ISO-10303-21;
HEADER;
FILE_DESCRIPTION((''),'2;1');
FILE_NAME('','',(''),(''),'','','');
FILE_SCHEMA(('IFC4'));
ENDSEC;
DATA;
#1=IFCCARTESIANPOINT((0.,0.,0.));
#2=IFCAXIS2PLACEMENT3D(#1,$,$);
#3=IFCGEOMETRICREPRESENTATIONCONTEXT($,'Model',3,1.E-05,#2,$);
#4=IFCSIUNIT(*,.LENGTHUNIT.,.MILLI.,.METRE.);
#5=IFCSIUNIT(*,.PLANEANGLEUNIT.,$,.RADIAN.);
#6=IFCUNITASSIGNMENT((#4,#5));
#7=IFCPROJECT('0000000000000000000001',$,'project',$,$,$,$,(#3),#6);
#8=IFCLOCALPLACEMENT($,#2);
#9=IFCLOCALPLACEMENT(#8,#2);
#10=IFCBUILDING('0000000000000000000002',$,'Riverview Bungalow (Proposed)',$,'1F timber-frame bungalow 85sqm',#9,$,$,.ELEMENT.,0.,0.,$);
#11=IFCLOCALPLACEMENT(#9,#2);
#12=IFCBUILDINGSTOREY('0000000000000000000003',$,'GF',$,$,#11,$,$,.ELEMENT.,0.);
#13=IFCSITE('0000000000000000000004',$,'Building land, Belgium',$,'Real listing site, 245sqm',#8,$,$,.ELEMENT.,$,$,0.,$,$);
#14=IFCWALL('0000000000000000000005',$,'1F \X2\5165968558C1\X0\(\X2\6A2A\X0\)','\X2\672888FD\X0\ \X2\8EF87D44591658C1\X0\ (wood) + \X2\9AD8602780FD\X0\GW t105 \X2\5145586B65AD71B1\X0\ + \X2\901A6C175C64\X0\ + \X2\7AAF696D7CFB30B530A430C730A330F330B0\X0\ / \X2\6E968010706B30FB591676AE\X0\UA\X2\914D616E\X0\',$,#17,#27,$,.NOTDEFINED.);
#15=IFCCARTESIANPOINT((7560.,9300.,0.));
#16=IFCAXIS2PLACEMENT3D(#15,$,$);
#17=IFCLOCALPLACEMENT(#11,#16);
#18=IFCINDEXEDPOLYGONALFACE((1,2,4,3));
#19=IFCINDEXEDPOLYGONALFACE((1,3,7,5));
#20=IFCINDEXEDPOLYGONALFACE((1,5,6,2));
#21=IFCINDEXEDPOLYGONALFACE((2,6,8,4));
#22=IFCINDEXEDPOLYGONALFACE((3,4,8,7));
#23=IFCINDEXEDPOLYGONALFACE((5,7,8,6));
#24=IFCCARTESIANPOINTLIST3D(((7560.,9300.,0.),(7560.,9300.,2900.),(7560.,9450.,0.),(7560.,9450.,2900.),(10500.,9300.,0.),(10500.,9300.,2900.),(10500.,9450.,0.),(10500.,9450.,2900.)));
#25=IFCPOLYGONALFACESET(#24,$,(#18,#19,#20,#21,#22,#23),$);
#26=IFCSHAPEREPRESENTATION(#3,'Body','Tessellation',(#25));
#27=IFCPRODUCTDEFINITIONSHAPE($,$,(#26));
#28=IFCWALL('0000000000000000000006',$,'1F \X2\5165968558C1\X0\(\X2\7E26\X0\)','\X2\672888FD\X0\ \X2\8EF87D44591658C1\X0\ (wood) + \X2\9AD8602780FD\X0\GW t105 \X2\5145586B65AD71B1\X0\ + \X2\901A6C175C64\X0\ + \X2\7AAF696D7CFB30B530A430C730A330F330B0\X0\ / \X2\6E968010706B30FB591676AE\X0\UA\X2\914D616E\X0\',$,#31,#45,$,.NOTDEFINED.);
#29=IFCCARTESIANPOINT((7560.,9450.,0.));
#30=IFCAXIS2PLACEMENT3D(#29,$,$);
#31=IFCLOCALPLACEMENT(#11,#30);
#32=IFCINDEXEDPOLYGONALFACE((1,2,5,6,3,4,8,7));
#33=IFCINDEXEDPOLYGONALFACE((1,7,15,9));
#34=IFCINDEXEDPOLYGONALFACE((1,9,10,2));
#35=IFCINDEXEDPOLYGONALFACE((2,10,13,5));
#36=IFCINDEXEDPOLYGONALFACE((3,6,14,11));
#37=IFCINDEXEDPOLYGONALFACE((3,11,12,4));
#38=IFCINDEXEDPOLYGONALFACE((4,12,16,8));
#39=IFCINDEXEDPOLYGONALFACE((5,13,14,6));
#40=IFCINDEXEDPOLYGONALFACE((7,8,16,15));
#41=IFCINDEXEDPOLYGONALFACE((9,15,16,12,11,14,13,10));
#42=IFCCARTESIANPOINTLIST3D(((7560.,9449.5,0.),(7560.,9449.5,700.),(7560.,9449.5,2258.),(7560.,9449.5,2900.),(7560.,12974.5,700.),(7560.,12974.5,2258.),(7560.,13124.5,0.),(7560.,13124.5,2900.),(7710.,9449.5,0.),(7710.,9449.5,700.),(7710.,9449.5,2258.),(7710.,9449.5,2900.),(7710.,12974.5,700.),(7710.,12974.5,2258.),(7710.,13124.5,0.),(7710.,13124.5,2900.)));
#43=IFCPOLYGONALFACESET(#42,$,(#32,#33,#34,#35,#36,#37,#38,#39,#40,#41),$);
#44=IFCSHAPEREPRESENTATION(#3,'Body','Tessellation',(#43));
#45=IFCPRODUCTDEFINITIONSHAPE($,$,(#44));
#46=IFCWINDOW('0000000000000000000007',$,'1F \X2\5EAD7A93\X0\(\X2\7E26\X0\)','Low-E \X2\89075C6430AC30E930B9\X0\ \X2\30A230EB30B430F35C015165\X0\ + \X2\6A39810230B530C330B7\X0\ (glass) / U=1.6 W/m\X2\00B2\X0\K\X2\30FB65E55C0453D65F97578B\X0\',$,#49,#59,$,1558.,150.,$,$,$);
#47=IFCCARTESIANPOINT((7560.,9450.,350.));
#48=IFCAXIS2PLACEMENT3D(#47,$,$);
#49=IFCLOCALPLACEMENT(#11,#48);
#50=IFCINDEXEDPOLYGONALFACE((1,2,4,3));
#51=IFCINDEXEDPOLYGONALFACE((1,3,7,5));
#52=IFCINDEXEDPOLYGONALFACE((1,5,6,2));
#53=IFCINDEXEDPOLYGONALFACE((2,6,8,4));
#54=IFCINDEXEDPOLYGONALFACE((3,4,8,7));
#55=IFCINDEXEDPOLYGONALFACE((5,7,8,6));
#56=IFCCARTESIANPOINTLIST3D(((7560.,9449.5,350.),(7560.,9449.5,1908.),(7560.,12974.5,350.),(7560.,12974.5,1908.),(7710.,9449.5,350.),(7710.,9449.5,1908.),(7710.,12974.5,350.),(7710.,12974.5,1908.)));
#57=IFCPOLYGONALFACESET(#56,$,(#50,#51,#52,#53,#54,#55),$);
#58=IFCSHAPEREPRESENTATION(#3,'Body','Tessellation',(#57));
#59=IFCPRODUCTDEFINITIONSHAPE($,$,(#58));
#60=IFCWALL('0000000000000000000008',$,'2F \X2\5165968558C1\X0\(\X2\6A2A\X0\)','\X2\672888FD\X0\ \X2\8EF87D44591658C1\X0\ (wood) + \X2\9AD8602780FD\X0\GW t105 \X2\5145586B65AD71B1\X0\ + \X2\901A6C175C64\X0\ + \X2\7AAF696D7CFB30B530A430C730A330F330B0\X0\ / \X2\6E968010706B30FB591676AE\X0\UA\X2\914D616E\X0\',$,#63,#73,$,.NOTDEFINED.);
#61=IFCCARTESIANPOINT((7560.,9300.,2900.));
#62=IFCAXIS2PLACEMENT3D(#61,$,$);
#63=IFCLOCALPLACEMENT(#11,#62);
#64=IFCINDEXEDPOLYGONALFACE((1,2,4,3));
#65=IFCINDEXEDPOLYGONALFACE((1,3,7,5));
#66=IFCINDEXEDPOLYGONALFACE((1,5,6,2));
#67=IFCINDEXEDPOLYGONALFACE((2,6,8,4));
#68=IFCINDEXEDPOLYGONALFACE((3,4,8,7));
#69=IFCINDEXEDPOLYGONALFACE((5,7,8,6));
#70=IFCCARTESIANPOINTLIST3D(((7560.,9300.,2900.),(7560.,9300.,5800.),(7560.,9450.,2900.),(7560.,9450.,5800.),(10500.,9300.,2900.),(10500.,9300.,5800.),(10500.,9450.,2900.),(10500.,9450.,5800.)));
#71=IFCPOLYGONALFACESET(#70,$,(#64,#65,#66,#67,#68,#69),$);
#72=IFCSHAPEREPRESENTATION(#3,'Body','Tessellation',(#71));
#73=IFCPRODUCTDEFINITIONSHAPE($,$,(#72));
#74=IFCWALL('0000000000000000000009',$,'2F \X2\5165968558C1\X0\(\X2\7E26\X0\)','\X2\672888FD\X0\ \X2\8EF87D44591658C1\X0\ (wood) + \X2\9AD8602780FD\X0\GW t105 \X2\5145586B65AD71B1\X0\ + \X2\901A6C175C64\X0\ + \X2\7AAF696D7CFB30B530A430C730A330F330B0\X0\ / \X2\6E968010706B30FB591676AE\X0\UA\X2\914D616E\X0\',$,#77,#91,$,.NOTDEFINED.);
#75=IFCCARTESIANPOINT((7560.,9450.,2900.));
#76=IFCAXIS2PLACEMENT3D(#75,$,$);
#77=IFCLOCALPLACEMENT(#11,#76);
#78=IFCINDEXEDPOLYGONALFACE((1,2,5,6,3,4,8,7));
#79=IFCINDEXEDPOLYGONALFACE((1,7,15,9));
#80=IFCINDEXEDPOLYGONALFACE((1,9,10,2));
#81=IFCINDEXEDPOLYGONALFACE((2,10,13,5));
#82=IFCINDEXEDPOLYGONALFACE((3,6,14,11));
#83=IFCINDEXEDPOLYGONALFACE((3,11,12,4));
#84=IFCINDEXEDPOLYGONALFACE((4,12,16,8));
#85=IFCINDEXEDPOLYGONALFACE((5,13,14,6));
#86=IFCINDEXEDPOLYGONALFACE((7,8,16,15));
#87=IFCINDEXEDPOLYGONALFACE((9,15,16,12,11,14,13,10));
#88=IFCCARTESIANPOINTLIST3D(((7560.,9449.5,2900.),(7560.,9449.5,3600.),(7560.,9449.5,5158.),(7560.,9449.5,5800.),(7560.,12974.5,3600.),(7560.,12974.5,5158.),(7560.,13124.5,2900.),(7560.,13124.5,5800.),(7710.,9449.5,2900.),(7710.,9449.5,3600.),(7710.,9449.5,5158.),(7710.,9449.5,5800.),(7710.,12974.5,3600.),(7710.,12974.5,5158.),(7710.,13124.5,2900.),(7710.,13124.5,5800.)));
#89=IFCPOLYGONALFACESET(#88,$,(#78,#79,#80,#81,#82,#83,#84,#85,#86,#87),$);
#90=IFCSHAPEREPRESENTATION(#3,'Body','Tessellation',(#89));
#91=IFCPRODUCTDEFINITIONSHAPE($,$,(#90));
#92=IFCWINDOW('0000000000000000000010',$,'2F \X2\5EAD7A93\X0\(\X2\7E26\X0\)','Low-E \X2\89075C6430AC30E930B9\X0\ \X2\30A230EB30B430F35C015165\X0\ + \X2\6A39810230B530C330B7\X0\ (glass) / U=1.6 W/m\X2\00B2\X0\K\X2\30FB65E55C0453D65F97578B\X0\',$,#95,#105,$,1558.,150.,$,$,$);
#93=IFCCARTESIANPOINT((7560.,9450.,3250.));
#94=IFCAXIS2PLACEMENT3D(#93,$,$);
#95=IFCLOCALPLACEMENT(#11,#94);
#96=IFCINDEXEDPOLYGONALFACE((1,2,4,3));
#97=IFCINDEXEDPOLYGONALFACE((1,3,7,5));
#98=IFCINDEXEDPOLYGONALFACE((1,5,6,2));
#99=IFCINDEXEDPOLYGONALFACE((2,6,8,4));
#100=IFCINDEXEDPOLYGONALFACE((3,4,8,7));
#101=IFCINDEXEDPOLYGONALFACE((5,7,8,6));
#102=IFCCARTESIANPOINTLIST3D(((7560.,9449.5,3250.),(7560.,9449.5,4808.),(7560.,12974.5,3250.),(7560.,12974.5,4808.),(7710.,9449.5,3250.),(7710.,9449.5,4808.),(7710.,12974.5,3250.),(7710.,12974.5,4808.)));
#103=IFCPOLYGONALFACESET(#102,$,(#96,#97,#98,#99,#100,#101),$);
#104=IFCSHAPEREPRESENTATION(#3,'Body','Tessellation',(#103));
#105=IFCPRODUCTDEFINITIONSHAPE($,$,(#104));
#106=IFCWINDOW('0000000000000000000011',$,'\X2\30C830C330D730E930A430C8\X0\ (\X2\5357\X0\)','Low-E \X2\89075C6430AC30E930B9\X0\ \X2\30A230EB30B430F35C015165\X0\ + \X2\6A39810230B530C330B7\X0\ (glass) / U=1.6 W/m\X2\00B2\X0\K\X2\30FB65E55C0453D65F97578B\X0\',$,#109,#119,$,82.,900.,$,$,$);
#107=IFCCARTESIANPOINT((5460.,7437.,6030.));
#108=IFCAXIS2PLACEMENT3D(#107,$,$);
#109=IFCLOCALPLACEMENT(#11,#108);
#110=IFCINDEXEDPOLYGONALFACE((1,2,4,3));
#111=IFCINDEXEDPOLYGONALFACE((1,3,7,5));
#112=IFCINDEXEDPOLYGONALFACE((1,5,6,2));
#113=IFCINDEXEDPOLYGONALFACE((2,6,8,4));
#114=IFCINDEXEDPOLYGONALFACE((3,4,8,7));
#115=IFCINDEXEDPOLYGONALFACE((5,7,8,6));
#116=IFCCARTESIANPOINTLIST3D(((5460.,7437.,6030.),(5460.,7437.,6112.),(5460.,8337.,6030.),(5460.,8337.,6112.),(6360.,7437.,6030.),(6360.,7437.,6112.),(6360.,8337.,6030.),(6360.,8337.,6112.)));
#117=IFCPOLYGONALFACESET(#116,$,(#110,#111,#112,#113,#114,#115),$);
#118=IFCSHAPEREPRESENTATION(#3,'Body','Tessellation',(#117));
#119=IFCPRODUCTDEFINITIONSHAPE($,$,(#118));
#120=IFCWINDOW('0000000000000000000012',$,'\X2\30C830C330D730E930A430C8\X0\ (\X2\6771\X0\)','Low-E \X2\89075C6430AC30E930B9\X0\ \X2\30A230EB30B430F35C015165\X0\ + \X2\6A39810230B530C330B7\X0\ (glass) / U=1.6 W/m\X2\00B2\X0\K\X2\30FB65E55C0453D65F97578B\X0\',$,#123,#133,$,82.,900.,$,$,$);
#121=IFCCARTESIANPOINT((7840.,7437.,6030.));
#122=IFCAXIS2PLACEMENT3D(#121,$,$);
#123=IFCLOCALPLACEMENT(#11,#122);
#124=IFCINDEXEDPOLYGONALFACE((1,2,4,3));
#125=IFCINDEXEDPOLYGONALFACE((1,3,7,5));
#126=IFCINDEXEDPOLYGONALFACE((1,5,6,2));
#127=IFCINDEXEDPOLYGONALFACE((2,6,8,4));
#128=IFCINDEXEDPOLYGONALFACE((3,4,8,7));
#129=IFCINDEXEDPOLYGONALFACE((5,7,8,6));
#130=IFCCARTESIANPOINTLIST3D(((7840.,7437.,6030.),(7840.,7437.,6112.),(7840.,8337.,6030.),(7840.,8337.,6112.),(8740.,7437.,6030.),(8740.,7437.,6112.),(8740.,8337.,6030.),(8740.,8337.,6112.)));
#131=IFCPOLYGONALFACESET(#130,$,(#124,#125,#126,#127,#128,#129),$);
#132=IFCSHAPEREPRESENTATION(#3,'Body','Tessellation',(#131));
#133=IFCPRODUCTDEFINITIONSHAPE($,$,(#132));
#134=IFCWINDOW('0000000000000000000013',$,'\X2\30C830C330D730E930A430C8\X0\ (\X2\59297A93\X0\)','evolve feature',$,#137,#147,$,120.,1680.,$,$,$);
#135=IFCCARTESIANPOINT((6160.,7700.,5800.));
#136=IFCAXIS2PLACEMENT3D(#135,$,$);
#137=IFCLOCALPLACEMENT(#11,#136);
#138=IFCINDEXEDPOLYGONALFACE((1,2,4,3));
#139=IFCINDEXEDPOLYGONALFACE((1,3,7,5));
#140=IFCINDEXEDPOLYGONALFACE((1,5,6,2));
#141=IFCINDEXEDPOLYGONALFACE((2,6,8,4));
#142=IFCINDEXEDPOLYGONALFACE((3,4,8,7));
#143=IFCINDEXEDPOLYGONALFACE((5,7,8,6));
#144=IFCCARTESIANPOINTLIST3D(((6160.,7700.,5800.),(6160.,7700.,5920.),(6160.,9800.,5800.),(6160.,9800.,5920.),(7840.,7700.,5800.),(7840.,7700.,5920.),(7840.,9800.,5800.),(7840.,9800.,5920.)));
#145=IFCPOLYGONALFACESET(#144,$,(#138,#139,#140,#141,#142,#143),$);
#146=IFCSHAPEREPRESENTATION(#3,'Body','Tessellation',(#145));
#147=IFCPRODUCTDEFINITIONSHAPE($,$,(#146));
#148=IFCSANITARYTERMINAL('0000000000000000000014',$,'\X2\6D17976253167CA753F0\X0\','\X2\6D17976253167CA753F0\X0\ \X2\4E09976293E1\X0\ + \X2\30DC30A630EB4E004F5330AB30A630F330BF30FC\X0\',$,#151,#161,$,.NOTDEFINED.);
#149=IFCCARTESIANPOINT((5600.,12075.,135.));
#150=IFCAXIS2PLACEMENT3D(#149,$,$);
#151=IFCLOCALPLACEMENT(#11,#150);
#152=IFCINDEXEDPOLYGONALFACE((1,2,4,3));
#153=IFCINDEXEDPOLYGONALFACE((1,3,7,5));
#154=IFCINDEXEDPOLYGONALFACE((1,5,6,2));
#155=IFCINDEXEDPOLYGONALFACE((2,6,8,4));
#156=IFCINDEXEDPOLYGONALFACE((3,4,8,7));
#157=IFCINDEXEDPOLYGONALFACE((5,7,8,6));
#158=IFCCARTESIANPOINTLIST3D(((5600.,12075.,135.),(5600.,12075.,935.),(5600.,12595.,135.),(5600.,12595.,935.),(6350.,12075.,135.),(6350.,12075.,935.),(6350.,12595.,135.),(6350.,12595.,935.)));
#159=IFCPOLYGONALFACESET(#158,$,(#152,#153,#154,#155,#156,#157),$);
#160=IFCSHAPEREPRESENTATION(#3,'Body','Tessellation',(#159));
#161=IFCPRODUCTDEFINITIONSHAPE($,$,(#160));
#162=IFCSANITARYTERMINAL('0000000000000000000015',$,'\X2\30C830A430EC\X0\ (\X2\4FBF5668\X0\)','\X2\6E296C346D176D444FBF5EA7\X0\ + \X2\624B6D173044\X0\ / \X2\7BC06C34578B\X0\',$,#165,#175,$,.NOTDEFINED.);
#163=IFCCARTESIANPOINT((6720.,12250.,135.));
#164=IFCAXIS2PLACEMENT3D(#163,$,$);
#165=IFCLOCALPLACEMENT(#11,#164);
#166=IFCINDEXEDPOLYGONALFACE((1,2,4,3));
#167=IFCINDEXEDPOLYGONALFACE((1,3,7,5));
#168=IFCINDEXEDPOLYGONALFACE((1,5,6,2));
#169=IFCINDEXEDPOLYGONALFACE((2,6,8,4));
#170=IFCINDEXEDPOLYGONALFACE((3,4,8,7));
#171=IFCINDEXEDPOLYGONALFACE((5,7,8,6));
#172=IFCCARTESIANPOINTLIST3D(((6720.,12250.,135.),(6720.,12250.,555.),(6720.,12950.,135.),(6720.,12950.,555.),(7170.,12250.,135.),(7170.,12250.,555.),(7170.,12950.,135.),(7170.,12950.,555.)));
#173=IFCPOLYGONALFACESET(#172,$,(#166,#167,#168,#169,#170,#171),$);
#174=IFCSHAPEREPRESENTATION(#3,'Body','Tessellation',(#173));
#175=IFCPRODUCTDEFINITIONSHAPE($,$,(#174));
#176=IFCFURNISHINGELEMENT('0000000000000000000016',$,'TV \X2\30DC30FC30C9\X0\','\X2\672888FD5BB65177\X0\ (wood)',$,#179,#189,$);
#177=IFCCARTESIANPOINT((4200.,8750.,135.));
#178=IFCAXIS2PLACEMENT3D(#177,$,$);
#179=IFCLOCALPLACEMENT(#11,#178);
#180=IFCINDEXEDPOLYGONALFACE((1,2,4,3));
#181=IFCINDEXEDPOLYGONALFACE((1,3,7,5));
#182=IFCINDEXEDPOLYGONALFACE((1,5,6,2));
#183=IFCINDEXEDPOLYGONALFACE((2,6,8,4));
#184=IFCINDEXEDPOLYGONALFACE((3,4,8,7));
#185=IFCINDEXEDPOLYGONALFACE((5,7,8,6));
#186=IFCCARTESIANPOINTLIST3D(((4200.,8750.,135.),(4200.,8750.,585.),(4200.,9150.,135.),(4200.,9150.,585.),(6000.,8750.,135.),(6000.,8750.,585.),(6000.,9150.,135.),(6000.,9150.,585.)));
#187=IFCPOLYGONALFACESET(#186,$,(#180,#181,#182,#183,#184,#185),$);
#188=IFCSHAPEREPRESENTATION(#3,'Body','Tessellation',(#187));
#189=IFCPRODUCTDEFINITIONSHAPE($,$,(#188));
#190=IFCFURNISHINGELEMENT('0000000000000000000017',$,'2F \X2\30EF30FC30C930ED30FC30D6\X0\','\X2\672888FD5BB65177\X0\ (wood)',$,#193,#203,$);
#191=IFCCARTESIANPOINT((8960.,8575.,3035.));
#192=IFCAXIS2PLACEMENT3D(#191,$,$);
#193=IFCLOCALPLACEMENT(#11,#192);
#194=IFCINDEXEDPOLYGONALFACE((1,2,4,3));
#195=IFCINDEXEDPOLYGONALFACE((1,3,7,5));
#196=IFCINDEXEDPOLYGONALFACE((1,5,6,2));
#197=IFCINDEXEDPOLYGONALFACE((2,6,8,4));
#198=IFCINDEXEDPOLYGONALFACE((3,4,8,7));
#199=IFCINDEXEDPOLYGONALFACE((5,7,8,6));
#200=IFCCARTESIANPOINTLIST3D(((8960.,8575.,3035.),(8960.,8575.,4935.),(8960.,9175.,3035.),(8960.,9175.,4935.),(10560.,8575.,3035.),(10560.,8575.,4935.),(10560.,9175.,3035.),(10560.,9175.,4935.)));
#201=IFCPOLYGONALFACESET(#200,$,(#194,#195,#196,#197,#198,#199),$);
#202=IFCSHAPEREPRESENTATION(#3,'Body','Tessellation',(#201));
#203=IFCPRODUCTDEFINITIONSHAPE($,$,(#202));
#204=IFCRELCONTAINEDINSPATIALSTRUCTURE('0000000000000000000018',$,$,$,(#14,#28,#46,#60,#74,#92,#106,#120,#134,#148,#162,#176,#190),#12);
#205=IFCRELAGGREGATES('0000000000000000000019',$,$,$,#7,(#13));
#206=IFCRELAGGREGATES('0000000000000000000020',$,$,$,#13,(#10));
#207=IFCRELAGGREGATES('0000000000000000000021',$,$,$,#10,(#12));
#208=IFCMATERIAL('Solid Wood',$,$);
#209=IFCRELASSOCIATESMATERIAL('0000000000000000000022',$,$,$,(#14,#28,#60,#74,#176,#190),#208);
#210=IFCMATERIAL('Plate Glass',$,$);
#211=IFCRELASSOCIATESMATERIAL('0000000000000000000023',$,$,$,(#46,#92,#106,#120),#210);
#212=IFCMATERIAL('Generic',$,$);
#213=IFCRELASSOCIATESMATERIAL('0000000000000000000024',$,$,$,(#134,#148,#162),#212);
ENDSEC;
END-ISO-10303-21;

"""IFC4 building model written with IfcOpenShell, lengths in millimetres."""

from ifc_helpers import new_model, si_unit, frame, frame_2d, origin, place, context, project, spatial, rectangle, extrude, material, element, fill, save


model = new_model("IFC4")

# Units and contexts
model_context = context("Model", 3, precision=1e-05, world=origin())
ifc_project = project(units=[si_unit("LENGTHUNIT", "METRE", prefix="MILLI"), si_unit("PLANEANGLEUNIT", "RADIAN")], contexts=[model_context])

# Site, building, storey
site_placement = place(None, origin())
site = spatial("IfcSite", under=ifc_project, at=site_placement, Name="Building land, Belgium", ObjectType="Real listing site, 245sqm", CompositionType="ELEMENT", RefElevation=0.0)
building_placement = place(site_placement, origin())
building = spatial("IfcBuilding", under=site, at=building_placement, Name="Riverview Bungalow (Proposed)", ObjectType="1F timber-frame bungalow 85sqm", CompositionType="ELEMENT", ElevationOfRefHeight=0.0, ElevationOfTerrain=0.0)
storey_placement = place(building_placement, origin())
storey = spatial("IfcBuildingStorey", under=building, at=storey_placement, Name="GF", CompositionType="ELEMENT", Elevation=0.0)

# Shared definitions
ifc_material_1 = material(Name="Solid Wood")

# Wall
wall_1_placement = place(storey_placement, frame((7560.0, 9300.0, 0.0)))
element("IfcWall", 1, at=wall_1_placement, inside=storey, material=ifc_material_1, Name="1F 入隅壁(横)", Description="木製 軸組外壁 (wood) + 高性能GW t105 充填断熱 + 通気層 + 窯業系サイディング / 準耐火・外皮UA配慮", PredefinedType="NOTDEFINED", context=model_context, shape_type="SweptSolid", body=[
    extrude(rectangle(XDim=2940.0, YDim=150.0, at=frame_2d((1470.0, 75.0))), frame((7560.0, 9300.0, 0.0)), (0.0, 0.0, 1.0), 2900.0),
])

# Wall, opening, window
wall_2_placement = place(storey_placement, frame((7560.0, 9450.0, 0.0)))
wall_2 = element("IfcWall", 2, at=wall_2_placement, inside=storey, material=ifc_material_1, Name="1F 入隅壁(縦)", Description="木製 軸組外壁 (wood) + 高性能GW t105 充填断熱 + 通気層 + 窯業系サイディング / 準耐火・外皮UA配慮", PredefinedType="NOTDEFINED", context=model_context, shape_type="SweptSolid", body=[
    extrude(rectangle(XDim=150.0, YDim=3675.0, at=frame_2d((75.0, 1837.0))), frame((7560.0, 9450.0, 0.0)), (0.0, 0.0, 1.0), 2900.0),
])
opening_1_placement = place(storey_placement, frame((7560.0, 9450.0, 350.0)))
opening_1 = element("IfcOpeningElement", 3, at=opening_1_placement, cuts=wall_2, PredefinedType="NOTDEFINED", context=model_context, shape_type="SweptSolid", body=[
    extrude(rectangle(XDim=150.0, YDim=3525.0, at=frame_2d((75.0, 1762.0))), frame((7560.0, 9450.0, 350.0)), (0.0, 0.0, 1.0), 1558.0),
])
ifc_material_2 = material(Name="Plate Glass")
window_1_placement = place(storey_placement, frame((7560.0, 9450.0, 350.0)))
window_1 = element("IfcWindow", 4, at=window_1_placement, inside=storey, material=ifc_material_2, Name="1F 庭窓(縦)", Description="Low-E 複層ガラス アルゴン封入 + 樹脂サッシ (glass) / U=1.6 W/m²K・日射取得型", OverallHeight=1558.0, OverallWidth=150.0, context=model_context, shape_type="SweptSolid", body=[
    extrude(rectangle(XDim=150.0, YDim=3525.0, at=frame_2d((75.0, 1762.0))), frame((7560.0, 9450.0, 350.0)), (0.0, 0.0, 1.0), 1558.0),
])
fill(opening_1, window_1)

# Wall
wall_3_placement = place(storey_placement, frame((7560.0, 9300.0, 2900.0)))
element("IfcWall", 5, at=wall_3_placement, inside=storey, material=ifc_material_1, Name="2F 入隅壁(横)", Description="木製 軸組外壁 (wood) + 高性能GW t105 充填断熱 + 通気層 + 窯業系サイディング / 準耐火・外皮UA配慮", PredefinedType="NOTDEFINED", context=model_context, shape_type="SweptSolid", body=[
    extrude(rectangle(XDim=2940.0, YDim=150.0, at=frame_2d((1470.0, 75.0))), frame((7560.0, 9300.0, 2900.0)), (0.0, 0.0, 1.0), 2900.0),
])

# Wall, opening, window
wall_4_placement = place(storey_placement, frame((7560.0, 9450.0, 2900.0)))
wall_4 = element("IfcWall", 6, at=wall_4_placement, inside=storey, material=ifc_material_1, Name="2F 入隅壁(縦)", Description="木製 軸組外壁 (wood) + 高性能GW t105 充填断熱 + 通気層 + 窯業系サイディング / 準耐火・外皮UA配慮", PredefinedType="NOTDEFINED", context=model_context, shape_type="SweptSolid", body=[
    extrude(rectangle(XDim=150.0, YDim=3675.0, at=frame_2d((75.0, 1837.0))), frame((7560.0, 9450.0, 2900.0)), (0.0, 0.0, 1.0), 2900.0),
])
opening_2_placement = place(storey_placement, frame((7560.0, 9450.0, 3250.0)))
opening_2 = element("IfcOpeningElement", 7, at=opening_2_placement, cuts=wall_4, PredefinedType="NOTDEFINED", context=model_context, shape_type="SweptSolid", body=[
    extrude(rectangle(XDim=150.0, YDim=3525.0, at=frame_2d((75.0, 1762.0))), frame((7560.0, 9450.0, 3250.0)), (0.0, 0.0, 1.0), 1558.0),
])
window_2_placement = place(storey_placement, frame((7560.0, 9450.0, 3250.0)))
window_2 = element("IfcWindow", 8, at=window_2_placement, inside=storey, material=ifc_material_2, Name="2F 庭窓(縦)", Description="Low-E 複層ガラス アルゴン封入 + 樹脂サッシ (glass) / U=1.6 W/m²K・日射取得型", OverallHeight=1558.0, OverallWidth=150.0, context=model_context, shape_type="SweptSolid", body=[
    extrude(rectangle(XDim=150.0, YDim=3525.0, at=frame_2d((75.0, 1762.0))), frame((7560.0, 9450.0, 3250.0)), (0.0, 0.0, 1.0), 1558.0),
])
fill(opening_2, window_2)

# Windows
window_3_placement = place(storey_placement, frame((5460.0, 7437.0, 6030.0)))
element("IfcWindow", 9, at=window_3_placement, inside=storey, material=ifc_material_2, Name="トップライト (南)", Description="Low-E 複層ガラス アルゴン封入 + 樹脂サッシ (glass) / U=1.6 W/m²K・日射取得型", OverallHeight=82.0, OverallWidth=900.0, context=model_context, shape_type="SweptSolid", body=[
    extrude(rectangle(XDim=900.0, YDim=900.0, at=frame_2d((450.0, 450.0))), frame((5460.0, 7437.0, 6030.0)), (0.0, 0.0, 1.0), 82.0),
])
window_4_placement = place(storey_placement, frame((7840.0, 7437.0, 6030.0)))
element("IfcWindow", 10, at=window_4_placement, inside=storey, material=ifc_material_2, Name="トップライト (東)", Description="Low-E 複層ガラス アルゴン封入 + 樹脂サッシ (glass) / U=1.6 W/m²K・日射取得型", OverallHeight=82.0, OverallWidth=900.0, context=model_context, shape_type="SweptSolid", body=[
    extrude(rectangle(XDim=900.0, YDim=900.0, at=frame_2d((450.0, 450.0))), frame((7840.0, 7437.0, 6030.0)), (0.0, 0.0, 1.0), 82.0),
])
ifc_material_3 = material(Name="Generic")
window_5_placement = place(storey_placement, frame((6160.0, 7700.0, 5800.0)))
element("IfcWindow", 11, at=window_5_placement, inside=storey, material=ifc_material_3, Name="トップライト (天窓)", Description="evolve feature", OverallHeight=120.0, OverallWidth=1680.0, context=model_context, shape_type="SweptSolid", body=[
    extrude(rectangle(XDim=1680.0, YDim=2100.0, at=frame_2d((840.0, 1050.0))), frame((6160.0, 7700.0, 5800.0)), (0.0, 0.0, 1.0), 120.0),
])

# Sanitary terminals
sanitary_terminal_1_placement = place(storey_placement, frame((5600.0, 12075.0, 135.0)))
element("IfcSanitaryTerminal", 12, at=sanitary_terminal_1_placement, inside=storey, material=ifc_material_3, Name="洗面化粧台", Description="洗面化粧台 三面鏡 + ボウル一体カウンター", PredefinedType="NOTDEFINED", context=model_context, shape_type="SweptSolid", body=[
    extrude(rectangle(XDim=750.0, YDim=520.0, at=frame_2d((375.0, 260.0))), frame((5600.0, 12075.0, 135.0)), (0.0, 0.0, 1.0), 800.0),
])
sanitary_terminal_2_placement = place(storey_placement, frame((6720.0, 12250.0, 135.0)))
element("IfcSanitaryTerminal", 13, at=sanitary_terminal_2_placement, inside=storey, material=ifc_material_3, Name="トイレ (便器)", Description="温水洗浄便座 + 手洗い / 節水型", PredefinedType="NOTDEFINED", context=model_context, shape_type="SweptSolid", body=[
    extrude(rectangle(XDim=450.0, YDim=700.0, at=frame_2d((225.0, 350.0))), frame((6720.0, 12250.0, 135.0)), (0.0, 0.0, 1.0), 420.0),
])

# Furnishing elements
furnishing_1_placement = place(storey_placement, frame((4200.0, 8750.0, 135.0)))
element("IfcFurnishingElement", 14, at=furnishing_1_placement, inside=storey, material=ifc_material_1, Name="TV ボード", Description="木製家具 (wood)", context=model_context, shape_type="SweptSolid", body=[
    extrude(rectangle(XDim=1800.0, YDim=400.0, at=frame_2d((900.0, 200.0))), frame((4200.0, 8750.0, 135.0)), (0.0, 0.0, 1.0), 450.0),
])
furnishing_2_placement = place(storey_placement, frame((8960.0, 8575.0, 3035.0)))
element("IfcFurnishingElement", 15, at=furnishing_2_placement, inside=storey, material=ifc_material_1, Name="2F ワードローブ", Description="木製家具 (wood)", context=model_context, shape_type="SweptSolid", body=[
    extrude(rectangle(XDim=1600.0, YDim=600.0, at=frame_2d((800.0, 300.0))), frame((8960.0, 8575.0, 3035.0)), (0.0, 0.0, 1.0), 1900.0),
])

save(model, "model.ifc")
